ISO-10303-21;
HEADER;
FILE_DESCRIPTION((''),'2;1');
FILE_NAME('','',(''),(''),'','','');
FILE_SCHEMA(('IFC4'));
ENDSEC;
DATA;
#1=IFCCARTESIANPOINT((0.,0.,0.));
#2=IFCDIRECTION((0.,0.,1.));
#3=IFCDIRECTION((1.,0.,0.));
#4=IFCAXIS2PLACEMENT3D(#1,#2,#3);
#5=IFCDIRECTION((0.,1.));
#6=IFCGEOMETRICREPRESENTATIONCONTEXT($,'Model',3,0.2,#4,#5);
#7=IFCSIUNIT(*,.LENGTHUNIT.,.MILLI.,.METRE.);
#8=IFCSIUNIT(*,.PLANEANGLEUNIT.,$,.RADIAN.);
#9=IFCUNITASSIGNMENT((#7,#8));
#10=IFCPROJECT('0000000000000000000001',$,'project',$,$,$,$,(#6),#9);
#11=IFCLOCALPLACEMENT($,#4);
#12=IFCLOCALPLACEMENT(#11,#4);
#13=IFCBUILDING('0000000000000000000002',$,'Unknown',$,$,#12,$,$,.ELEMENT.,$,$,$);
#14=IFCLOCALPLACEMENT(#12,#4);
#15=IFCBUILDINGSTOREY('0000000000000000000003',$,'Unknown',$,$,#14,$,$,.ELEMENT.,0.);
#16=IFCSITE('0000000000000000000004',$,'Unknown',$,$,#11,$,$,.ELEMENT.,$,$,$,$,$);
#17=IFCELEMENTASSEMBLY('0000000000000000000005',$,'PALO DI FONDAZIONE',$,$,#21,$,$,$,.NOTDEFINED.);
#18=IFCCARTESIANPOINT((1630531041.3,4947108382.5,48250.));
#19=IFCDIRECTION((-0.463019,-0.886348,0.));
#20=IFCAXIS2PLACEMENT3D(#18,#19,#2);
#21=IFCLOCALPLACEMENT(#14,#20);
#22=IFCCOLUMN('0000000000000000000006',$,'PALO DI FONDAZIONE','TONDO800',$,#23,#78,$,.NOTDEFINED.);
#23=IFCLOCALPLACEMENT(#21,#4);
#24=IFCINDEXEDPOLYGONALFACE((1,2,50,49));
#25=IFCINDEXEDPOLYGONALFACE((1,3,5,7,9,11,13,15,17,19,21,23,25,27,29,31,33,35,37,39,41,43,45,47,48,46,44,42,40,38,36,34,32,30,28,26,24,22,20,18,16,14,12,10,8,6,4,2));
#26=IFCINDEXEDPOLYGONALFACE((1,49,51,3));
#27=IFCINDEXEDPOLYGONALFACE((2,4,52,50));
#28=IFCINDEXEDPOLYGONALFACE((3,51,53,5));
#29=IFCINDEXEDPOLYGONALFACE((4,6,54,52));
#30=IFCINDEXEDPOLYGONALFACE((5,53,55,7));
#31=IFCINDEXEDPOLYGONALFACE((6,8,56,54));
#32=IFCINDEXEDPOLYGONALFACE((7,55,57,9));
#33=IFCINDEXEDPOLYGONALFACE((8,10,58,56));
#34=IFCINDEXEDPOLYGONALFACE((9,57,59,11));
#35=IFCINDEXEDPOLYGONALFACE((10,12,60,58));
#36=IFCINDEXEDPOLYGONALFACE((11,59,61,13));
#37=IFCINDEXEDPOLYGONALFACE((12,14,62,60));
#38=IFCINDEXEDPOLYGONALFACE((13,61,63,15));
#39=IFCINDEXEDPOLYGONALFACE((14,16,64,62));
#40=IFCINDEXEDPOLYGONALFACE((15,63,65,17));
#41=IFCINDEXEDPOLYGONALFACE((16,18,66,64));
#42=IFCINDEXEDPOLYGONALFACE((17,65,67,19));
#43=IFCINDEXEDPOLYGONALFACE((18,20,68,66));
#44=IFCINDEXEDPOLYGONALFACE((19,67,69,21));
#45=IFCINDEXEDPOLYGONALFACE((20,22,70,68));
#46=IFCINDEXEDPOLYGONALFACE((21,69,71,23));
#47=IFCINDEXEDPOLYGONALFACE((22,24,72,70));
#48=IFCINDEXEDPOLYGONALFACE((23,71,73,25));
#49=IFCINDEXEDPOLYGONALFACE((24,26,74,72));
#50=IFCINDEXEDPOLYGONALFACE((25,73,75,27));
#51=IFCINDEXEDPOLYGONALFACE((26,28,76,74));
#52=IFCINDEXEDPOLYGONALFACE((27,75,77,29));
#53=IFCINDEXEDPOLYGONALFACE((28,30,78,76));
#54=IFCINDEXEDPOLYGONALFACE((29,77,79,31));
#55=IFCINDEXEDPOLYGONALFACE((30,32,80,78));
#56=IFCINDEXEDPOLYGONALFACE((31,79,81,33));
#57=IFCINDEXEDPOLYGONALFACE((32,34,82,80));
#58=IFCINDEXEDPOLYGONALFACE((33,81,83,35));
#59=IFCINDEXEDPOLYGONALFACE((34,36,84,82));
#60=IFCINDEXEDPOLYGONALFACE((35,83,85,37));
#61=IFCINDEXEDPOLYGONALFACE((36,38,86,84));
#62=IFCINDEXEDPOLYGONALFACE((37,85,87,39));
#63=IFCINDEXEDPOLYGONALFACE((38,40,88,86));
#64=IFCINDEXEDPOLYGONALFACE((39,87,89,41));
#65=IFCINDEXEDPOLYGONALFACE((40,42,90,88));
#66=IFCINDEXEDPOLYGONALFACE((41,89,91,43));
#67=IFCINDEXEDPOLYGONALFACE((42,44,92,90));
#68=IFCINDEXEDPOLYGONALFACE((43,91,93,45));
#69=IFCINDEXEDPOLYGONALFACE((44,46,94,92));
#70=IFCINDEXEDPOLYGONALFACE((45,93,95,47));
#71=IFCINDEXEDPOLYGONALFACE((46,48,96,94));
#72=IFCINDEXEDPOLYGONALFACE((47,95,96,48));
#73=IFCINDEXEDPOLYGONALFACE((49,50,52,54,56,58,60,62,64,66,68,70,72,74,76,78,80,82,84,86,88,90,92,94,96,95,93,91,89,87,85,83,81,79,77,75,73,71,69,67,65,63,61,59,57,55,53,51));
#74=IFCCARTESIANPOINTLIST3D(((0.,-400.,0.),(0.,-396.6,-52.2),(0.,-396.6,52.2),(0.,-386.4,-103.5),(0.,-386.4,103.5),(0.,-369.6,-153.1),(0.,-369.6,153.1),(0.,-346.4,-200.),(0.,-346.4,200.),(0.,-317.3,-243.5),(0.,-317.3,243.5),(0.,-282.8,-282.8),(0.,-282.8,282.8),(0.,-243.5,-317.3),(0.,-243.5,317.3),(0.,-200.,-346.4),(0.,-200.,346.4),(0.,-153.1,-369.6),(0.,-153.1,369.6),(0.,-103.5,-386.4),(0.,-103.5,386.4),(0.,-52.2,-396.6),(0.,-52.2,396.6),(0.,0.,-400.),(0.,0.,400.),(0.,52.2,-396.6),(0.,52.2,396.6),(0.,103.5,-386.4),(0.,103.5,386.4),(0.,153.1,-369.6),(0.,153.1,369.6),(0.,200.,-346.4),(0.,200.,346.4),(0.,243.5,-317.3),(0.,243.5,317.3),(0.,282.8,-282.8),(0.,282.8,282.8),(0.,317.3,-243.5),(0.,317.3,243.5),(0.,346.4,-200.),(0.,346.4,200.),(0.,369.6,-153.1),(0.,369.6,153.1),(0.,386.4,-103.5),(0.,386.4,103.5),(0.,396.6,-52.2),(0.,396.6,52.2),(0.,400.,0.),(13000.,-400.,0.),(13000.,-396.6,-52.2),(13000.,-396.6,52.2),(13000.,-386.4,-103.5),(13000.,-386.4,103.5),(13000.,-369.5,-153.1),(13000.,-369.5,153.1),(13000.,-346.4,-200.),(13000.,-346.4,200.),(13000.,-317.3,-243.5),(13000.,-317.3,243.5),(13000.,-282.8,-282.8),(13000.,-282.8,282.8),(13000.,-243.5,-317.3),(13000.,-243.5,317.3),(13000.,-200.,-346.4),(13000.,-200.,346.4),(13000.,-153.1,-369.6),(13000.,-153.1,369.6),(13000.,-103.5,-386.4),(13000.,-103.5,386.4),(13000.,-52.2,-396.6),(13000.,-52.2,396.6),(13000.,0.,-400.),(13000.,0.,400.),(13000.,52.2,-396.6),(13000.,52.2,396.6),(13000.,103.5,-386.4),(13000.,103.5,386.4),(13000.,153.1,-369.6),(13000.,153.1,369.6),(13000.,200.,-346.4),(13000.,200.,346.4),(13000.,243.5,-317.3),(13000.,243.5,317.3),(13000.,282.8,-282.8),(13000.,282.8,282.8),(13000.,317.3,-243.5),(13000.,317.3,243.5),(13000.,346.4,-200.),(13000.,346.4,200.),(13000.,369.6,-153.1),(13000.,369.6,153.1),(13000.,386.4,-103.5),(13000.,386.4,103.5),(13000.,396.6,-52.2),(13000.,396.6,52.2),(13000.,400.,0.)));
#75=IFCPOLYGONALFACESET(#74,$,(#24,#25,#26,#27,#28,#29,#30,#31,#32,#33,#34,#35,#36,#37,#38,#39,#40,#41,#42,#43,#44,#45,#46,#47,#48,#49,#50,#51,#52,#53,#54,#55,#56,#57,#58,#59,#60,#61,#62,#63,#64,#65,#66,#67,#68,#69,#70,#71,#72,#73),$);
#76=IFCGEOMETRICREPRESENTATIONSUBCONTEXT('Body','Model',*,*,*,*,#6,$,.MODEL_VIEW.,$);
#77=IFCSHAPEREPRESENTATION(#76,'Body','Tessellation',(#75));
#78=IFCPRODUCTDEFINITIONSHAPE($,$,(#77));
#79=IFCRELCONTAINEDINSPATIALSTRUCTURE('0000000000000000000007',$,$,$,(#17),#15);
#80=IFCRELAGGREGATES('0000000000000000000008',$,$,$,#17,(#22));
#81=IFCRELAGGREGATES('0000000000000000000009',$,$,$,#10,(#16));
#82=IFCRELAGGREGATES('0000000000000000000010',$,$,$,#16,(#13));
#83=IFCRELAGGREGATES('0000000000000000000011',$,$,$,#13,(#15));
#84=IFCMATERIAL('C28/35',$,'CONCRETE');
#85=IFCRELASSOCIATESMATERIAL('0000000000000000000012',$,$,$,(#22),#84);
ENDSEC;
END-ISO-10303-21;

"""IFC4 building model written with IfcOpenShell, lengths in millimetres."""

from ifc_helpers import new_model, si_unit, direction, frame, origin_with_axes, place, context, subcontext, project, spatial, line, indexed_curve, outline, extrude, material, element, aggregate, save


model = new_model("IFC4")

# Units and contexts
model_context = context("Model", 3, precision=0.2, world=origin_with_axes(), true_north=direction((0.0, 1.0)))
body_context = subcontext(model_context, "Body", "Model", "MODEL_VIEW")
ifc_project = project(units=[si_unit("LENGTHUNIT", "METRE", prefix="MILLI"), si_unit("PLANEANGLEUNIT", "RADIAN")], contexts=[model_context])

# Site, building, storey
site_placement = place(None, origin_with_axes())
site = spatial("IfcSite", under=ifc_project, at=site_placement, Name="Unknown", CompositionType="ELEMENT")
building_placement = place(site_placement, origin_with_axes())
building = spatial("IfcBuilding", under=site, at=building_placement, Name="Unknown", CompositionType="ELEMENT")
storey_placement = place(building_placement, origin_with_axes())
storey = spatial("IfcBuildingStorey", under=building, at=storey_placement, Name="Unknown", CompositionType="ELEMENT", Elevation=0.0)

# Element assembly, column
ifc_material_1 = material(Name="C28/35", Category="CONCRETE")
assembly_1_placement = place(storey_placement, frame((1630531041.3, 4947108382.5, 48250.0), z_axis=(-0.463019, -0.886348, 0.0), x_axis=(0.0, 0.0, 1.0)))
assembly_1 = element("IfcElementAssembly", 1, at=assembly_1_placement, inside=storey, Name="PALO DI FONDAZIONE", PredefinedType="NOTDEFINED")
column_1_placement = place(assembly_1_placement, origin_with_axes())
column_1 = element("IfcColumn", 2, at=column_1_placement, material=ifc_material_1, Name="PALO DI FONDAZIONE", Description="TONDO800", PredefinedType="NOTDEFINED", context=body_context, shape_type="SolidModel", body=[
    extrude(outline(indexed_curve([(400.0, 0.0), (396.6, 52.2), (386.4, 103.5), (369.6, 153.1), (346.4, 200.0), (317.3, 243.5), (282.8, 282.8), (243.5, 317.3), (200.0, 346.4), (153.1, 369.6), (103.5, 386.4), (52.2, 396.6), (0.0, 400.0), (-52.2, 396.6), (-103.5, 386.4), (-153.1, 369.6), (-200.0, 346.4), (-243.5, 317.3), (-282.8, 282.8), (-317.3, 243.5), (-346.4, 200.0), (-369.6, 153.1), (-386.4, 103.5), (-396.6, 52.2), (-400.0, 0.0), (-396.6, -52.2), (-386.4, -103.5), (-369.6, -153.1), (-346.4, -200.0), (-317.3, -243.5), (-282.8, -282.8), (-243.5, -317.3), (-200.0, -346.4), (-153.1, -369.6), (-103.5, -386.4), (-52.2, -396.6), (0.0, -400.0), (52.2, -396.6), (103.5, -386.4), (153.1, -369.6), (200.0, -346.4), (243.5, -317.3), (282.8, -282.8), (317.3, -243.5), (346.4, -200.0), (369.6, -153.1), (386.4, -103.5), (396.6, -52.2)], segments=[line(1, 2, 3, 4, 5, 6, 7, 8, 9, 10, 11, 12, 13, 14, 15, 16, 17, 18, 19, 20, 21, 22, 23, 24, 25, 26, 27, 28, 29, 30, 31, 32, 33, 34, 35, 36, 37, 38, 39, 40, 41, 42, 43, 44, 45, 46, 47, 48, 1)])), frame((0.0, 0.0, 0.0), z_axis=(-1.0, 0.0, 0.0), x_axis=(0.0, 0.0, 1.0)), (0.0, 0.0, -1.0), 13000.0),
])
aggregate(assembly_1, [column_1])

save(model, "model.ifc")
